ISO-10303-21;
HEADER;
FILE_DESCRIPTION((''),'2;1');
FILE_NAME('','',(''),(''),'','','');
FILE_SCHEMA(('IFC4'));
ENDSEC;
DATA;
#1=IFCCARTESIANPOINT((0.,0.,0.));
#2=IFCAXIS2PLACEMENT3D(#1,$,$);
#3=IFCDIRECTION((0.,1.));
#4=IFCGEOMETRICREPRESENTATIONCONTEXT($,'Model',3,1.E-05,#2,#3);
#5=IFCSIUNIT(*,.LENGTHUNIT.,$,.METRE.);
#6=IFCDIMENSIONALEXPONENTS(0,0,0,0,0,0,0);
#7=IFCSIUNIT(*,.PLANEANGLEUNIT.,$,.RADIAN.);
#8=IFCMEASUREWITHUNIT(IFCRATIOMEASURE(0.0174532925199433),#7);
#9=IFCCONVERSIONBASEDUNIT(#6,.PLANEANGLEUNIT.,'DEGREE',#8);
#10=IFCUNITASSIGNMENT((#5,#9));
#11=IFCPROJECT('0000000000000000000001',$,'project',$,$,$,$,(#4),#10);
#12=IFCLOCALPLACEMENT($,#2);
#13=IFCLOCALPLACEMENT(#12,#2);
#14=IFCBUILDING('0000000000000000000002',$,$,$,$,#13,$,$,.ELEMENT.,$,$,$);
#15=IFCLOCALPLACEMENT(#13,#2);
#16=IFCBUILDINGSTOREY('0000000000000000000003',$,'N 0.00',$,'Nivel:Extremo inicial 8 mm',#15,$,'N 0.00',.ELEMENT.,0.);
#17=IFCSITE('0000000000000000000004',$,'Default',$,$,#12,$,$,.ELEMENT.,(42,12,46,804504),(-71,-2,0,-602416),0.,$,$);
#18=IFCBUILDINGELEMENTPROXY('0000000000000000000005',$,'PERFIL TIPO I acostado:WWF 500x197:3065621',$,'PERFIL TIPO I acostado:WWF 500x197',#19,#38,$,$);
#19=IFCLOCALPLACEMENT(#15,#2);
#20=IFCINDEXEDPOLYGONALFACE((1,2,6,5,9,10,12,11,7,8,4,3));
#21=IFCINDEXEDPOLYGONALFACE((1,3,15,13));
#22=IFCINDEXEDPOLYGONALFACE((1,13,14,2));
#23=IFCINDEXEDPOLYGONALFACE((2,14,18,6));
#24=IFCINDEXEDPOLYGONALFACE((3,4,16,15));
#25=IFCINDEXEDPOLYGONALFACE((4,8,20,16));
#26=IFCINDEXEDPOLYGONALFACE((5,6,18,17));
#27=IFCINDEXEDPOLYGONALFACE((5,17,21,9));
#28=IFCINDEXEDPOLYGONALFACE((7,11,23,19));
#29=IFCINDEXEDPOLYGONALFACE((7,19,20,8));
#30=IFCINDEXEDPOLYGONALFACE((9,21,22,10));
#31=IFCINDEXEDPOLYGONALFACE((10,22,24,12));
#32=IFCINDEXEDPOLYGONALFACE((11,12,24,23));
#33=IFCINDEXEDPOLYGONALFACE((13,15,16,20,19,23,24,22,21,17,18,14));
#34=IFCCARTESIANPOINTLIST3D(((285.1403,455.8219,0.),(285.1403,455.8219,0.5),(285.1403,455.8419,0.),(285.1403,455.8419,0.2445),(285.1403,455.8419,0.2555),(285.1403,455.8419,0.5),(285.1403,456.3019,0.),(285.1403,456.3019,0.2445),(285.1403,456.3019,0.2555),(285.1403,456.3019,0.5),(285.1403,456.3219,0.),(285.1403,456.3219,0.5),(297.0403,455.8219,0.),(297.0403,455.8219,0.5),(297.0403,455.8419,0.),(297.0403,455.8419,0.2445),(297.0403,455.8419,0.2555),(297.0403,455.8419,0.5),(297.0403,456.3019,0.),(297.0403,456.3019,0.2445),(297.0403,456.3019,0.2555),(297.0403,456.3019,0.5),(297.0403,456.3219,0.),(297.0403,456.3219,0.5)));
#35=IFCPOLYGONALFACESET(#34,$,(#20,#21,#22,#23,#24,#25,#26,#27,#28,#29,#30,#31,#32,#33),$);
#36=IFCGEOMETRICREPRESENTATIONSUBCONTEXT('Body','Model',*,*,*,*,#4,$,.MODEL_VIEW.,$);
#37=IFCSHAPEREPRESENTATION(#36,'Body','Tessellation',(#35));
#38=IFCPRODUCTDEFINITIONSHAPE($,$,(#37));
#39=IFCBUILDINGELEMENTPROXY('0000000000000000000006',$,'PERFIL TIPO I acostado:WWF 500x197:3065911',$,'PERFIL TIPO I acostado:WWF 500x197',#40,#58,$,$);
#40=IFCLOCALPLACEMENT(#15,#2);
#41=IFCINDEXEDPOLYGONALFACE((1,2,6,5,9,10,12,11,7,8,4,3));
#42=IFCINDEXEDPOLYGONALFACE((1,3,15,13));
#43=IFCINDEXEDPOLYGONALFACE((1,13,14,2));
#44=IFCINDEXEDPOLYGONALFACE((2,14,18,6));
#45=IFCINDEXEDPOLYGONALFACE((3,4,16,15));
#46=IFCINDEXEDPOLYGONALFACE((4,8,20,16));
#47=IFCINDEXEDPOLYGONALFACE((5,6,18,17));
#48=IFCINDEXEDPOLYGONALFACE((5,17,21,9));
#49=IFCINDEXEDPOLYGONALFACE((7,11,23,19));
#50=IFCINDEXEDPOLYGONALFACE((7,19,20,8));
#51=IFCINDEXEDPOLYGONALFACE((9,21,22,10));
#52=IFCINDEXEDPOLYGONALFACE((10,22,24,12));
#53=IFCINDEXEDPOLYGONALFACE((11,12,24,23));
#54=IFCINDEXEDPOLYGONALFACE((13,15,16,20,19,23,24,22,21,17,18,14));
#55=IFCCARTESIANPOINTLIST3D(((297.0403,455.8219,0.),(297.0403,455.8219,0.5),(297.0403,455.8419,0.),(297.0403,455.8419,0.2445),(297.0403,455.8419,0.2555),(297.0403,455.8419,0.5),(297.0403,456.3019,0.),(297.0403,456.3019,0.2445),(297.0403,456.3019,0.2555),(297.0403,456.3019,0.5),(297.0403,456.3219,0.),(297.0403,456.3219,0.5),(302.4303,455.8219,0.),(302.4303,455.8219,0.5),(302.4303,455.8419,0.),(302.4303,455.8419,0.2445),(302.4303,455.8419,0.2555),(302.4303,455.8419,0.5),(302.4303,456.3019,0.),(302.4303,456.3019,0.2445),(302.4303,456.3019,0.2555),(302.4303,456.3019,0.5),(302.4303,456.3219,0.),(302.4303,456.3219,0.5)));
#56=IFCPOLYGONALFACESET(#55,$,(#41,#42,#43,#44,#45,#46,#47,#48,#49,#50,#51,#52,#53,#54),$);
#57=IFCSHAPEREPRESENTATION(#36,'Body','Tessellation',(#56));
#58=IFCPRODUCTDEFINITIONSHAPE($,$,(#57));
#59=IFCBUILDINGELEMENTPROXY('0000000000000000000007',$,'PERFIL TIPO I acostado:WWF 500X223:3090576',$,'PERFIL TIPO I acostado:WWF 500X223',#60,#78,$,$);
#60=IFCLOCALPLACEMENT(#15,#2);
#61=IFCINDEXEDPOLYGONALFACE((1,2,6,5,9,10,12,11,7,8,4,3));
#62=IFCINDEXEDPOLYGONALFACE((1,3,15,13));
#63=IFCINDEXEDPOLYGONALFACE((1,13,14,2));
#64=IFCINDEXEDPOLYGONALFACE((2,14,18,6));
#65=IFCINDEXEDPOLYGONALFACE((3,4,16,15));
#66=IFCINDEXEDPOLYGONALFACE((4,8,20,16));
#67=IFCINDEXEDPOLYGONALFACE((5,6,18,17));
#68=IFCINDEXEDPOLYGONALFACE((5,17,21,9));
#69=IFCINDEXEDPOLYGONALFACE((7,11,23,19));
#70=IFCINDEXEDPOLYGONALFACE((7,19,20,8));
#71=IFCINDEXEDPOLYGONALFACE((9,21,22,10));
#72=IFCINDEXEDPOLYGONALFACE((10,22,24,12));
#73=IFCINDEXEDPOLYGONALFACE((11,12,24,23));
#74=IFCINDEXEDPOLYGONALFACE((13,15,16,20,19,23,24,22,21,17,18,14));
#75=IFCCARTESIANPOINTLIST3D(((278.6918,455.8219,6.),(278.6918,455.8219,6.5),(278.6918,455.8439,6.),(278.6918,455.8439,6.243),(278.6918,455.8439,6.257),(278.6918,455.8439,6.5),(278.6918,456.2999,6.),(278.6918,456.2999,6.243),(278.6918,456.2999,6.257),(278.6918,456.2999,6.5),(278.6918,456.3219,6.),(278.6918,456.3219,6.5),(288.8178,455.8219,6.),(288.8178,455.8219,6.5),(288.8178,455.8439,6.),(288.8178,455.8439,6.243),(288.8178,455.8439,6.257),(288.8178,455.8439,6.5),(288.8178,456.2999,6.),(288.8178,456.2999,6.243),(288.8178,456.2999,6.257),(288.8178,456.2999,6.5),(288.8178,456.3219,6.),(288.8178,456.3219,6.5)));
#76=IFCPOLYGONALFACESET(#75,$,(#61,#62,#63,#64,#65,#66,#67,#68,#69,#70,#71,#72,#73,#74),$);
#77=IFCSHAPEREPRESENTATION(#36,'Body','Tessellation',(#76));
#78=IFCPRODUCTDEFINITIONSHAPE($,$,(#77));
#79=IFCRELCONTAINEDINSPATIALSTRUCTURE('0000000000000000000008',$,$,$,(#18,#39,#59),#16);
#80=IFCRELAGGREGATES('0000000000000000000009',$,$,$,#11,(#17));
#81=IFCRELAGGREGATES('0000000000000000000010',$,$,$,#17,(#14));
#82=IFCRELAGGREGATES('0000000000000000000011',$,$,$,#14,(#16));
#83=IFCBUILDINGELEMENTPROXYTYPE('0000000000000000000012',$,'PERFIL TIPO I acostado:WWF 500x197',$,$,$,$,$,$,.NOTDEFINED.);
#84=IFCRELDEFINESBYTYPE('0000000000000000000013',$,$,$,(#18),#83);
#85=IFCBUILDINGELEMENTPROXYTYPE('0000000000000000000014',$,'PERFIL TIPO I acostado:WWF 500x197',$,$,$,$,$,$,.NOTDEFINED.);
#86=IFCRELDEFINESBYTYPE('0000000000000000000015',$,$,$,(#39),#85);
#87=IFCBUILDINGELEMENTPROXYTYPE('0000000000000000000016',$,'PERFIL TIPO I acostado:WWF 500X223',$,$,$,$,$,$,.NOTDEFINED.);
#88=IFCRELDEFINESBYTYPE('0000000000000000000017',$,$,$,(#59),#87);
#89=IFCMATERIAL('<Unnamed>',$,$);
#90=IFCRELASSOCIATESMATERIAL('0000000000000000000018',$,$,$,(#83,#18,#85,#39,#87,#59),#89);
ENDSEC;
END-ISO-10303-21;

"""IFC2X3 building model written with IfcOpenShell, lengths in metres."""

from ifc_helpers import new_model, entity, si_unit, converted_unit, direction, frame, origin, place, context, subcontext, project, spatial, polyline, outline, extrude, source, transform, mapped, material, type_object, type_shapes, element, save


model = new_model("IFC2X3")

# Units and contexts
model_context = context("Model", 3, precision=1e-05, world=origin(), true_north=direction((0.0, 1.0)))
body_context = subcontext(model_context, "Body", "Model", "MODEL_VIEW")
ifc_project = project(units=[si_unit("LENGTHUNIT", "METRE"), converted_unit("PLANEANGLEUNIT", "DEGREE", entity("IfcRatioMeasure", 0.0174532925199433), si_unit("PLANEANGLEUNIT", "RADIAN"), dimensions=[0, 0, 0, 0, 0, 0, 0])], contexts=[model_context])

# Site, building, storey
site_placement = place(None, origin())
site = spatial("IfcSite", under=ifc_project, at=site_placement, Name="Default", CompositionType="ELEMENT", RefLatitude=(42, 12, 46, 804504), RefLongitude=(-71, -2, 0, -602416), RefElevation=0.0)
building_placement = place(site_placement, origin())
building = spatial("IfcBuilding", under=site, at=building_placement, CompositionType="ELEMENT")
storey_placement = place(building_placement, origin())
storey = spatial("IfcBuildingStorey", under=building, at=storey_placement, Name="N 0.00", ObjectType="Nivel:Extremo inicial 8 mm", LongName="N 0.00", CompositionType="ELEMENT", Elevation=0.0)

# Shared definitions
ifc_material_1 = material(Name="<Unnamed>")

# Building element proxies
building_element_proxy_type_1 = type_object("IfcBuildingElementProxyType", Name="PERFIL TIPO I acostado:WWF 500x197", PredefinedType="NOTDEFINED", material=ifc_material_1)
shared_shape_1 = source(origin(), body_context, "Body", "SweptSolid", [
    extrude(outline(polyline([(0.23, -0.25), (0.25, -0.25), (0.25, 0.25), (0.23, 0.25), (0.23, 0.0055), (-0.23, 0.0055), (-0.23, 0.25), (-0.25, 0.25), (-0.25, -0.25), (-0.23, -0.25), (-0.23, -0.0055), (0.23, -0.0055), (0.23, -0.25)])), frame((0.0, 0.0, 0.25), z_axis=(1.0, 0.0, 0.0), x_axis=(0.0, -1.0, 0.0)), (0.0, 0.0, 1.0), 11.9),
])
type_shapes(building_element_proxy_type_1, [shared_shape_1])
proxy_1_placement = place(storey_placement, frame((285.1403, 456.0719, 0.0)))
element("IfcBuildingElementProxy", 1, at=proxy_1_placement, inside=storey, type_object=building_element_proxy_type_1, material=ifc_material_1, Name="PERFIL TIPO I acostado:WWF 500x197:3065621", ObjectType="PERFIL TIPO I acostado:WWF 500x197", context=body_context, shape_type="MappedRepresentation", body=[
    mapped(shared_shape_1, transform((0.0, 0.0, 0.0), scale=1.0)),
])
building_element_proxy_type_2 = type_object("IfcBuildingElementProxyType", Name="PERFIL TIPO I acostado:WWF 500x197", PredefinedType="NOTDEFINED", material=ifc_material_1)
shared_shape_2 = source(origin(), body_context, "Body", "SweptSolid", [
    extrude(outline(polyline([(0.23, -0.25), (0.25, -0.25), (0.25, 0.25), (0.23, 0.25), (0.23, 0.0055), (-0.23, 0.0055), (-0.23, 0.25), (-0.25, 0.25), (-0.25, -0.25), (-0.23, -0.25), (-0.23, -0.0055), (0.23, -0.0055), (0.23, -0.25)])), frame((0.0, 0.0, 0.25), z_axis=(1.0, 0.0, 0.0), x_axis=(0.0, -1.0, 0.0)), (0.0, 0.0, 1.0), 5.39),
])
type_shapes(building_element_proxy_type_2, [shared_shape_2])
proxy_2_placement = place(storey_placement, frame((297.0403, 456.0719, 0.0)))
element("IfcBuildingElementProxy", 2, at=proxy_2_placement, inside=storey, type_object=building_element_proxy_type_2, material=ifc_material_1, Name="PERFIL TIPO I acostado:WWF 500x197:3065911", ObjectType="PERFIL TIPO I acostado:WWF 500x197", context=body_context, shape_type="MappedRepresentation", body=[
    mapped(shared_shape_2, transform((0.0, 0.0, 0.0), scale=1.0)),
])
building_element_proxy_type_3 = type_object("IfcBuildingElementProxyType", Name="PERFIL TIPO I acostado:WWF 500X223", PredefinedType="NOTDEFINED", material=ifc_material_1)
shared_shape_3 = source(origin(), body_context, "Body", "SweptSolid", [
    extrude(outline(polyline([(0.228, -0.25), (0.25, -0.25), (0.25, 0.25), (0.228, 0.25), (0.228, 0.007), (-0.228, 0.007), (-0.228, 0.25), (-0.25, 0.25), (-0.25, -0.25), (-0.228, -0.25), (-0.228, -0.007), (0.228, -0.007), (0.228, -0.25)])), frame((0.0, 0.0, 0.25), z_axis=(1.0, 0.0, 0.0), x_axis=(0.0, -1.0, 0.0)), (0.0, 0.0, 1.0), 10.126),
])
type_shapes(building_element_proxy_type_3, [shared_shape_3])
proxy_3_placement = place(storey_placement, frame((278.6918, 456.0719, 6.0)))
element("IfcBuildingElementProxy", 3, at=proxy_3_placement, inside=storey, type_object=building_element_proxy_type_3, material=ifc_material_1, Name="PERFIL TIPO I acostado:WWF 500X223:3090576", ObjectType="PERFIL TIPO I acostado:WWF 500X223", context=body_context, shape_type="MappedRepresentation", body=[
    mapped(shared_shape_3, transform((0.0, 0.0, 0.0), scale=1.0)),
])

save(model, "model.ifc")
